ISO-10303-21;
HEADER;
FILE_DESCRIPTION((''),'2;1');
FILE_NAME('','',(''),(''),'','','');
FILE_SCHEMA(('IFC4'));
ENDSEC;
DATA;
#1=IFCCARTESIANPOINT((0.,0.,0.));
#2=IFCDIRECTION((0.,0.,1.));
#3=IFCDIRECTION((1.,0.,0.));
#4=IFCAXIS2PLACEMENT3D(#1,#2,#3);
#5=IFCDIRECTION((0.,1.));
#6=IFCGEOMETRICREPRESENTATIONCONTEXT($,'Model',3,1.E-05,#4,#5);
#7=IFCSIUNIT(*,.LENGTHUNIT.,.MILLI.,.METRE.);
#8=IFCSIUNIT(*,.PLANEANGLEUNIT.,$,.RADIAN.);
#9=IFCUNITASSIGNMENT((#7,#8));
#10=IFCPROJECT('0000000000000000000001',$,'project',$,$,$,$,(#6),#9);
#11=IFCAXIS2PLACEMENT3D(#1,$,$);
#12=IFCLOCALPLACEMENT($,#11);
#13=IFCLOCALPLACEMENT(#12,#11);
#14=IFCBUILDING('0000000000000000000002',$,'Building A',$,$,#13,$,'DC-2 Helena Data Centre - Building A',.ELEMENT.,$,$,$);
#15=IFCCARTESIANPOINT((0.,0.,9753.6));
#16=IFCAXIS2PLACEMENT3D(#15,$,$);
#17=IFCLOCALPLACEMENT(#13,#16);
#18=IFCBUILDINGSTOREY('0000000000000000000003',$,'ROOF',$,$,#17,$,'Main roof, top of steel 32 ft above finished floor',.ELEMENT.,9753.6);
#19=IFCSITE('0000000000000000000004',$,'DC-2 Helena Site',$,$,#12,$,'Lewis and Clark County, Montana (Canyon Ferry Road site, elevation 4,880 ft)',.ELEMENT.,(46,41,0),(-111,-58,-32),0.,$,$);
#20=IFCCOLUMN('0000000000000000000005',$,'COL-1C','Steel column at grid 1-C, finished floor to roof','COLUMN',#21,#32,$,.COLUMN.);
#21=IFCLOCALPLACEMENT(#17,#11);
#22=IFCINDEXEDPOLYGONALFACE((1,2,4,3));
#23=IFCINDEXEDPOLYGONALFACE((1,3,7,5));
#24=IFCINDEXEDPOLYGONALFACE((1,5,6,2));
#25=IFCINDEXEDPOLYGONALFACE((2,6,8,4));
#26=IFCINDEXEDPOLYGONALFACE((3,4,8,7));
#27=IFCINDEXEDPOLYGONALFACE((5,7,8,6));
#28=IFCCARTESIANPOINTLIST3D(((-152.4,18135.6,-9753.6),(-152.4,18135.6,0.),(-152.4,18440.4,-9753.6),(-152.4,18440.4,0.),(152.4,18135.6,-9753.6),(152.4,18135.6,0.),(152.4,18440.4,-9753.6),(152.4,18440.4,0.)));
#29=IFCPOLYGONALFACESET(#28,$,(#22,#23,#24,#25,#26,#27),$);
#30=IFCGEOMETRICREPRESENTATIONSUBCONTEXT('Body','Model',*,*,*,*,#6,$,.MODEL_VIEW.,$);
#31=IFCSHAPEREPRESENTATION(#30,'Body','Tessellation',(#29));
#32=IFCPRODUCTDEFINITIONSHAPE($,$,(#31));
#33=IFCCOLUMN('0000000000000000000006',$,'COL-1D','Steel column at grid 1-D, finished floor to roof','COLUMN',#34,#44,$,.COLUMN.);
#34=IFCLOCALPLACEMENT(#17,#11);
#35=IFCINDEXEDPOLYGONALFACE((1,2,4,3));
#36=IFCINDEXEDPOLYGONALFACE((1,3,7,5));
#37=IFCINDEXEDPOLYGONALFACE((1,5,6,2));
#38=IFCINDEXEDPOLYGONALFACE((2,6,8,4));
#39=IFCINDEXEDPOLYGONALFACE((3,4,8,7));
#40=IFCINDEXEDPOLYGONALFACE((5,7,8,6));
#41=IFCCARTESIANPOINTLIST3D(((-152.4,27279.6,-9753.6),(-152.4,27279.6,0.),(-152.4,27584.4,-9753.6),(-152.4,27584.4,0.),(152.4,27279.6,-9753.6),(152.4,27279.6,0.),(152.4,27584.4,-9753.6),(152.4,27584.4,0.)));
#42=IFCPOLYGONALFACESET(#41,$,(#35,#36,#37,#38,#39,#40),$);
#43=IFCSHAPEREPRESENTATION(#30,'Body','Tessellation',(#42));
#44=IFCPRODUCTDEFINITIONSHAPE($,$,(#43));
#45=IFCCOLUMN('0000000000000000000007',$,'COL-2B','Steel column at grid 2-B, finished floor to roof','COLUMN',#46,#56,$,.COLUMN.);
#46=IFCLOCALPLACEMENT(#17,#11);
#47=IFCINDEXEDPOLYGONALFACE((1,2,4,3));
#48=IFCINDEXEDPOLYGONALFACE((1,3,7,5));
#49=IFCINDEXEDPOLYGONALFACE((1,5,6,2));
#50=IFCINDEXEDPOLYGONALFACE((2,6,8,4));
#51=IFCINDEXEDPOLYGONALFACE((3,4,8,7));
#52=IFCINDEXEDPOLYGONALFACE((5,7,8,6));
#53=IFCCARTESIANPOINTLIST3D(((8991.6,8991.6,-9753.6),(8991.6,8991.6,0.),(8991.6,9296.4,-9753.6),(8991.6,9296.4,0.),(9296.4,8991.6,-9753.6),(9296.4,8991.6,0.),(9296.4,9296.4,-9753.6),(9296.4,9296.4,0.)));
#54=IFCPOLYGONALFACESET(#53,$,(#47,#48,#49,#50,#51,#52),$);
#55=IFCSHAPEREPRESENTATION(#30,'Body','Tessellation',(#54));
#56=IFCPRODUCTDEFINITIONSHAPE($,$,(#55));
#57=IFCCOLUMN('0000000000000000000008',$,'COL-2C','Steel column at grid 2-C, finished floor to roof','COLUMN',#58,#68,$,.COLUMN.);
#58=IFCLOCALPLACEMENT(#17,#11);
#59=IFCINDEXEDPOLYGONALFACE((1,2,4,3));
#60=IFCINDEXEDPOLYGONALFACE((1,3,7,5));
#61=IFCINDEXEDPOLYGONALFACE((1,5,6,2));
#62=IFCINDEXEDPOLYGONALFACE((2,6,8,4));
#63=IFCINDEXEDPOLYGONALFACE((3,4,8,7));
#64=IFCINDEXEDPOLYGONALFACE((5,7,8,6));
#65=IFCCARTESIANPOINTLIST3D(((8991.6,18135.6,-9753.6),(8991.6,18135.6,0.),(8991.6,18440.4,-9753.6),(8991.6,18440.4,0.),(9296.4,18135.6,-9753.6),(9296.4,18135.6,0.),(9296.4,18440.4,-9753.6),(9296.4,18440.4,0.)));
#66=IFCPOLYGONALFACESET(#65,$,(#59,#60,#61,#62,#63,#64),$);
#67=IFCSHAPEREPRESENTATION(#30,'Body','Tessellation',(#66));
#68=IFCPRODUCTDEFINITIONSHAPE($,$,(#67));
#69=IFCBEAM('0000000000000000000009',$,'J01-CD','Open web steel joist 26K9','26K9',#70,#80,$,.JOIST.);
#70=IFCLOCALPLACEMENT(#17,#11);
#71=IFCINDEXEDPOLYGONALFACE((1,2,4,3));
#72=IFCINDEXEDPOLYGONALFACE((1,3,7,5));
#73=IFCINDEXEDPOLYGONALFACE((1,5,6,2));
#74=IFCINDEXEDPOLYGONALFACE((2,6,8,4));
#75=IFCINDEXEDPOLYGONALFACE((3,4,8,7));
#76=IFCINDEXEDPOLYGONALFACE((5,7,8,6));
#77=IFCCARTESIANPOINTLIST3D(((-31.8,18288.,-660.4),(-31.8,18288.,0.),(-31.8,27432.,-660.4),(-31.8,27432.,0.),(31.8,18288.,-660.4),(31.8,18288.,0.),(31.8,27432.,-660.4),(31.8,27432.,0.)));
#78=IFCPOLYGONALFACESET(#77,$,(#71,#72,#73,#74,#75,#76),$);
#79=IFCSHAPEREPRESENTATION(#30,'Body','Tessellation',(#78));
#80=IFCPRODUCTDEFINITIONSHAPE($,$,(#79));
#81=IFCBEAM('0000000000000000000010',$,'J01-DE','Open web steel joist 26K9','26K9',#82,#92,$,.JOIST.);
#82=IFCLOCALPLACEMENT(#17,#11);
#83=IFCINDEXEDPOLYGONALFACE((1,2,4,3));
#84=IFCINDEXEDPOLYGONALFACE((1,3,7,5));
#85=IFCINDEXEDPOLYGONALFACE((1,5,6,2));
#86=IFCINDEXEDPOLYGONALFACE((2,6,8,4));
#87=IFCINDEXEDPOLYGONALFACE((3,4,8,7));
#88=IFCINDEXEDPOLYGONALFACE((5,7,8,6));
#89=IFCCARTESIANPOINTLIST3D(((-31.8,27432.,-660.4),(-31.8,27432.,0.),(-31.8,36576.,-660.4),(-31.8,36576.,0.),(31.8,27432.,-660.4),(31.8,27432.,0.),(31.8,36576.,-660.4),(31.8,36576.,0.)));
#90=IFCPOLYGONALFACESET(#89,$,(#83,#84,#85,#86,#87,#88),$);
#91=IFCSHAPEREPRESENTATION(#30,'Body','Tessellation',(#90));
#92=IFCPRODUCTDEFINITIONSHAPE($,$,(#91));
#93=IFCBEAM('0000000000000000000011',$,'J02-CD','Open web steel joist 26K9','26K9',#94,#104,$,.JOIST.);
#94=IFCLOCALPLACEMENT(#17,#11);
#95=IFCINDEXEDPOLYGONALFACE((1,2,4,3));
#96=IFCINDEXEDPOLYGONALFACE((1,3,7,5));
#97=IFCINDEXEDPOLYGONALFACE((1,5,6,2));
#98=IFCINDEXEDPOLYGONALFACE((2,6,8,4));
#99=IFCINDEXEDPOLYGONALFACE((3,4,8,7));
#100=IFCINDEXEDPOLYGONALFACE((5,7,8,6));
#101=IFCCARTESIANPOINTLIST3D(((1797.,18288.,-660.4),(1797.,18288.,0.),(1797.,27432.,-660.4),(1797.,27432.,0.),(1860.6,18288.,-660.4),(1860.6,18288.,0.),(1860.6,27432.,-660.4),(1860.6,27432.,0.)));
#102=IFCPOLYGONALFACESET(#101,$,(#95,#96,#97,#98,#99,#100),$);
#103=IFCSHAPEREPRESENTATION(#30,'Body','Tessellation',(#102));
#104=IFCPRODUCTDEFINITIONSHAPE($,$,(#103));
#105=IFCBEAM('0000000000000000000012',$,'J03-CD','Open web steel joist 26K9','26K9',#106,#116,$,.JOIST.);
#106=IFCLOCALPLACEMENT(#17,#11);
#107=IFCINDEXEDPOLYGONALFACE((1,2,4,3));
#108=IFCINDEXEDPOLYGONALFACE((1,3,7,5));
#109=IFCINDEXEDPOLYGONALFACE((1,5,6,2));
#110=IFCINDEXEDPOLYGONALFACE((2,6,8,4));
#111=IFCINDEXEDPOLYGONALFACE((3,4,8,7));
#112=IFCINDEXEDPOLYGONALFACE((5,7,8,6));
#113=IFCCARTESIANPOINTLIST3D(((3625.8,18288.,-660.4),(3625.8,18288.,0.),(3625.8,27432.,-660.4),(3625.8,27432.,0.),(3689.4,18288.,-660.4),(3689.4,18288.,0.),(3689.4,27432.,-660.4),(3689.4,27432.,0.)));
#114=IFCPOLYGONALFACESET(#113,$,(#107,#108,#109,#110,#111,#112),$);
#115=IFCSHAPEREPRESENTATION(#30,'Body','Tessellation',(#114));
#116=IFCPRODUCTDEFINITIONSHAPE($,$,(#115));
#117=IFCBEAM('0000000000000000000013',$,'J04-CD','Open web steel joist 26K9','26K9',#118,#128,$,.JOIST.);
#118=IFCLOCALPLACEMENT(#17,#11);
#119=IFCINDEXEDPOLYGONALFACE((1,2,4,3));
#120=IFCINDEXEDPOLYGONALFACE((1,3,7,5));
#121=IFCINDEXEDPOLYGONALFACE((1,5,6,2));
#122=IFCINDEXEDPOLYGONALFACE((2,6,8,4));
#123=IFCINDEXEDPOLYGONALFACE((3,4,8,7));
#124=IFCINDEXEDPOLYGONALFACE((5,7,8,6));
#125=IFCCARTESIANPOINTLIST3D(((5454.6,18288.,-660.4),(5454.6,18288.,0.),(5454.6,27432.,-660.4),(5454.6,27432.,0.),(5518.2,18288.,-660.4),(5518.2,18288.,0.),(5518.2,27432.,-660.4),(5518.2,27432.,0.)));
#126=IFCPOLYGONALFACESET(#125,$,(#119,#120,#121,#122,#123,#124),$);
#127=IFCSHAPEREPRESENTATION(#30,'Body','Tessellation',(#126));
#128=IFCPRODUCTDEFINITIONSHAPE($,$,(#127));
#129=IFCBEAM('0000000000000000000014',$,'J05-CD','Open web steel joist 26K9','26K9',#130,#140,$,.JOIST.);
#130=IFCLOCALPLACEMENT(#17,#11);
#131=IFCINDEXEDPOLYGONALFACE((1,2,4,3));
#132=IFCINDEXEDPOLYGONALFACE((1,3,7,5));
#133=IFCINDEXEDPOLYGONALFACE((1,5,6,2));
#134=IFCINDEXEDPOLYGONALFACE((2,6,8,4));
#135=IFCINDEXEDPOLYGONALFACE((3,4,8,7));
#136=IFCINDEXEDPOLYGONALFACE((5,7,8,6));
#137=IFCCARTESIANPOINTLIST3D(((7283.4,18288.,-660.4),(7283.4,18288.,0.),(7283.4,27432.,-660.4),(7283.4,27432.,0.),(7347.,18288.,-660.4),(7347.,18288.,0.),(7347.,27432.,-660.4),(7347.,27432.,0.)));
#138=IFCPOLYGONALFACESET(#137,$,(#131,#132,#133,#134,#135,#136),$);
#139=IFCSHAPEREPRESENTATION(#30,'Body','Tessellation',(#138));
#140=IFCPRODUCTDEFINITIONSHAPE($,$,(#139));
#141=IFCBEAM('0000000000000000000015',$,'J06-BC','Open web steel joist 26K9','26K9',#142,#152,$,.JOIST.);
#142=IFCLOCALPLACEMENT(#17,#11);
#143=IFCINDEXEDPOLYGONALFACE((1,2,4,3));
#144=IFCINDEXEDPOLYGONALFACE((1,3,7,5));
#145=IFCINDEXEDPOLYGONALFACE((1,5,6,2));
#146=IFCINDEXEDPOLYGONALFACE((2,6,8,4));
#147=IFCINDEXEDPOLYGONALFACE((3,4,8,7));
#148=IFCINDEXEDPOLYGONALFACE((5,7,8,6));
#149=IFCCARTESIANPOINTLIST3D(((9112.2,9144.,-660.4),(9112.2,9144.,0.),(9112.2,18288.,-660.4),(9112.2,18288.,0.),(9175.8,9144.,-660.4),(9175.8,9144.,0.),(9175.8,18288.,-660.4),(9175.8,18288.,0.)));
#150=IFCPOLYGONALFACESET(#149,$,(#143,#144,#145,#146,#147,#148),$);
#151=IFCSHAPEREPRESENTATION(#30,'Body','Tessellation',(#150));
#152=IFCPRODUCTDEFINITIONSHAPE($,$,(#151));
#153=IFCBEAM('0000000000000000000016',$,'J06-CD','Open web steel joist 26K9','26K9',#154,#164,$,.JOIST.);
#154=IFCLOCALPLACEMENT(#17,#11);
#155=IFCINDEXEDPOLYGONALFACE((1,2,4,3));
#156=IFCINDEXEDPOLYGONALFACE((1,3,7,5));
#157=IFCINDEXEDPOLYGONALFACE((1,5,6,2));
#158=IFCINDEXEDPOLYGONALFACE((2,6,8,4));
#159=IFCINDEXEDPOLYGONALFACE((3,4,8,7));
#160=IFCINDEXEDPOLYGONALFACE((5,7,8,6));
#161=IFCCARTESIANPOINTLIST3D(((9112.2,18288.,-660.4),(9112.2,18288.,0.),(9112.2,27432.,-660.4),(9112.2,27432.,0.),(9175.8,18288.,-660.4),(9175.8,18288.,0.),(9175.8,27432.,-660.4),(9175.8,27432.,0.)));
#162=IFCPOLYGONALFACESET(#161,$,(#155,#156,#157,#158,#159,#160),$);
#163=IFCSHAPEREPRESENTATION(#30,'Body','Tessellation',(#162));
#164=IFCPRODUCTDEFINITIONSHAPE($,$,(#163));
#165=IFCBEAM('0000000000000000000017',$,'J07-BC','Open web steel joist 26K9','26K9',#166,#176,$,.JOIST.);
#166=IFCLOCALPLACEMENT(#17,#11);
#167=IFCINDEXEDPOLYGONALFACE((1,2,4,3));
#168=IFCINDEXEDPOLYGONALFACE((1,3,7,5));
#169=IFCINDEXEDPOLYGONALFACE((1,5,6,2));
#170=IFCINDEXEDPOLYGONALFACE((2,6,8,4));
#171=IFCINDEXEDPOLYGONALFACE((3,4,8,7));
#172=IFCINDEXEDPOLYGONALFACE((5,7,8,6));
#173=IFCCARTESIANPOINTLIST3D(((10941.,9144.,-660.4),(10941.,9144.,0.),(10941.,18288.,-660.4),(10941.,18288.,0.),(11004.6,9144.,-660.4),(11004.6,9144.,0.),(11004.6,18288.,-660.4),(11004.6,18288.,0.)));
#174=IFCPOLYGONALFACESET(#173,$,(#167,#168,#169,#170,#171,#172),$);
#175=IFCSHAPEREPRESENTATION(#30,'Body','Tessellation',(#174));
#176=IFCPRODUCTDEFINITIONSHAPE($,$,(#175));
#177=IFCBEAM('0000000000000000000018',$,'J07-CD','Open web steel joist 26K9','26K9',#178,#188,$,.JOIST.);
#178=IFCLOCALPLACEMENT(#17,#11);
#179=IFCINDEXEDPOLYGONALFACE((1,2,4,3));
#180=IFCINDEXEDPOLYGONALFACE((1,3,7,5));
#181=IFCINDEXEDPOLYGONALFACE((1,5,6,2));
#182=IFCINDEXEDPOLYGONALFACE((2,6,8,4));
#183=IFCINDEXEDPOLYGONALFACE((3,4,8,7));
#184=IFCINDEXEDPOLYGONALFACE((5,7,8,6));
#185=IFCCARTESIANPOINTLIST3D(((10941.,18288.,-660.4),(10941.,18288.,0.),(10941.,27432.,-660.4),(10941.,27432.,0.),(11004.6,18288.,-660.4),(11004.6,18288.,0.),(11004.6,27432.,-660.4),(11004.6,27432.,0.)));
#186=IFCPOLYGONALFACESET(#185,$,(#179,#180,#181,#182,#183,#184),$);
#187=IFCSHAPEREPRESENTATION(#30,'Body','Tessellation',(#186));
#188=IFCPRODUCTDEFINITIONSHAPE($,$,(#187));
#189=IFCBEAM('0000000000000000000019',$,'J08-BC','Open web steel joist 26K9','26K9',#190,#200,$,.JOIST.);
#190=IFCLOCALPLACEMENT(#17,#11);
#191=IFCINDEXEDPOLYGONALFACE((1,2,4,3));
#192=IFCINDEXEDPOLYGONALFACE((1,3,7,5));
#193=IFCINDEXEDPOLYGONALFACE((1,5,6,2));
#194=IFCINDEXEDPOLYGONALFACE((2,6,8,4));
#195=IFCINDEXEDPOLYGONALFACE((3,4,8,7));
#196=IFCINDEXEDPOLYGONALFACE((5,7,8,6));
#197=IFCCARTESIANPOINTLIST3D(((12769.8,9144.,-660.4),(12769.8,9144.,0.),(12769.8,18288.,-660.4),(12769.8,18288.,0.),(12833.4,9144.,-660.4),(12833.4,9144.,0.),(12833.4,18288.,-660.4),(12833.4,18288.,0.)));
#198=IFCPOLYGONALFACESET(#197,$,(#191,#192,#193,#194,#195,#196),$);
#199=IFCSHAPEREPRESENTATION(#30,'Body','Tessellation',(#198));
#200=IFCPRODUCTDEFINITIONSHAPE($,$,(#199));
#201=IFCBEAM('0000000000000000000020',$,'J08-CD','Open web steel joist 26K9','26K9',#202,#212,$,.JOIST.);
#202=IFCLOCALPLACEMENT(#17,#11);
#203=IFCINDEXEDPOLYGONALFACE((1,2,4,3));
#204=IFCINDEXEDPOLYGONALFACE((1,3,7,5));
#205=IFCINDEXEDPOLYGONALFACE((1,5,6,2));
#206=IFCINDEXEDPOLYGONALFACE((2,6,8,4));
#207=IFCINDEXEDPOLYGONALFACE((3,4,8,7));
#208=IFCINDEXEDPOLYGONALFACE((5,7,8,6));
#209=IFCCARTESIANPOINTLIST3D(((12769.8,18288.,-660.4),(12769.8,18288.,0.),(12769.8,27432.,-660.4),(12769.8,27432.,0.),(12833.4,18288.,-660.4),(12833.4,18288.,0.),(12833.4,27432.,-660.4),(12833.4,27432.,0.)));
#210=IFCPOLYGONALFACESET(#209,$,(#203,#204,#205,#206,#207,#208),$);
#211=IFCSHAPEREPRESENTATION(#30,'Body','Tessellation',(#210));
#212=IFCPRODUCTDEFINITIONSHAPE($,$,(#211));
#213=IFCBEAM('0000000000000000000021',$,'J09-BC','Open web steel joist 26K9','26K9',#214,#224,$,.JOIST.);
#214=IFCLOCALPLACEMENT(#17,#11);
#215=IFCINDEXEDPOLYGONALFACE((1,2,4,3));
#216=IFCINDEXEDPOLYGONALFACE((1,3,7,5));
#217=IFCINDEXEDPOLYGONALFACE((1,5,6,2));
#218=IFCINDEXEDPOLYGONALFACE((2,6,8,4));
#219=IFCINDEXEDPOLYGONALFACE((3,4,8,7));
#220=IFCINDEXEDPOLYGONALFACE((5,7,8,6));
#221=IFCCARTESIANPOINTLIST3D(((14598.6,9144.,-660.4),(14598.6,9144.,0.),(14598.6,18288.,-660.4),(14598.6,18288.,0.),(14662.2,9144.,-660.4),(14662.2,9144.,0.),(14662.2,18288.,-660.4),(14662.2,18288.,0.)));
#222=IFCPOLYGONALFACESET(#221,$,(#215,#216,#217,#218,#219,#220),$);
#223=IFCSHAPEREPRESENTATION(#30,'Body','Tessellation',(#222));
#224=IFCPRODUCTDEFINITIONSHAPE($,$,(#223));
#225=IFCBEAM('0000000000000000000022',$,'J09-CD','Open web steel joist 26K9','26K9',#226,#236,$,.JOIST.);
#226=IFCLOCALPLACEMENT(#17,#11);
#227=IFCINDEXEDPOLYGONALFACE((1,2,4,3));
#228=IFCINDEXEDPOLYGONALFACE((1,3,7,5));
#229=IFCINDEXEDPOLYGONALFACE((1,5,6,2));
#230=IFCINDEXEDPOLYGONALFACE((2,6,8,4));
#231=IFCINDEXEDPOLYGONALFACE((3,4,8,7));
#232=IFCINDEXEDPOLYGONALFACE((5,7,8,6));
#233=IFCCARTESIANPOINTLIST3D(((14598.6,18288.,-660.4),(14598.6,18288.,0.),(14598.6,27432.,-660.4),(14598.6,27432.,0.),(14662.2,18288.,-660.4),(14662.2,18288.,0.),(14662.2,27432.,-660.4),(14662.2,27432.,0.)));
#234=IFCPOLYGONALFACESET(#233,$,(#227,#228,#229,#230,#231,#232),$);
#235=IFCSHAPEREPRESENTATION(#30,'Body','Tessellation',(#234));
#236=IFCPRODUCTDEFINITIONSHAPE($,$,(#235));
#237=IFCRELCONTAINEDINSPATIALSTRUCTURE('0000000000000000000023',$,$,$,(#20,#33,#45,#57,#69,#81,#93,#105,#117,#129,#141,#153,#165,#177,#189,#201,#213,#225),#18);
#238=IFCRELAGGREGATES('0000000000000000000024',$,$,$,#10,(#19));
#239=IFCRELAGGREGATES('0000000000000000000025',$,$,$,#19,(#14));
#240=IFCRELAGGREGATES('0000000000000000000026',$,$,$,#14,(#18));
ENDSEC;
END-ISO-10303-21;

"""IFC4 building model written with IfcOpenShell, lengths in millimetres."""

from ifc_helpers import new_model, si_unit, direction, frame, origin, origin_with_axes, origin_2d, place, context, subcontext, project, spatial, rectangle, extrude, element, save


model = new_model("IFC4")

# Units and contexts
model_context = context("Model", 3, precision=1e-05, world=origin_with_axes(), true_north=direction((0.0, 1.0)))
body_context = subcontext(model_context, "Body", "Model", "MODEL_VIEW")
ifc_project = project(units=[si_unit("LENGTHUNIT", "METRE", prefix="MILLI"), si_unit("PLANEANGLEUNIT", "RADIAN")], contexts=[model_context])

# Site, building, storey
site_placement = place(None, origin())
site = spatial("IfcSite", under=ifc_project, at=site_placement, Name="DC-2 Helena Site", LongName="Lewis and Clark County, Montana (Canyon Ferry Road site, elevation 4,880 ft)", CompositionType="ELEMENT", RefLatitude=(46, 41, 0), RefLongitude=(-111, -58, -32), RefElevation=0.0)
building_placement = place(site_placement, origin())
building = spatial("IfcBuilding", under=site, at=building_placement, Name="Building A", LongName="DC-2 Helena Data Centre - Building A", CompositionType="ELEMENT")
storey_placement = place(building_placement, frame((0.0, 0.0, 9753.6)))
storey = spatial("IfcBuildingStorey", under=building, at=storey_placement, Name="ROOF", LongName="Main roof, top of steel 32 ft above finished floor", CompositionType="ELEMENT", Elevation=9753.6)

# Columns
placement_1 = place(storey_placement, frame((0.0, 18288.0, -9753.6)))
element("IfcColumn", 1, at=placement_1, inside=storey, Name="COL-1C", Description="Steel column at grid 1-C, finished floor to roof", ObjectType="COLUMN", PredefinedType="COLUMN", context=body_context, shape_type="SweptSolid", body=[
    extrude(rectangle(XDim=304.8, YDim=304.8, at=origin_2d()), origin(), (0.0, 0.0, 1.0), 9753.6),
])
for number, where, name, description in (
    (2, (0.0, 27432.0, -9753.6), "COL-1D", "Steel column at grid 1-D, finished floor to roof"),
    (3, (9144.0, 9144.0, -9753.6), "COL-2B", "Steel column at grid 2-B, finished floor to roof"),
    (4, (9144.0, 18288.0, -9753.6), "COL-2C", "Steel column at grid 2-C, finished floor to roof"),
):
    element("IfcColumn", number, at=place(storey_placement, frame(where)), inside=storey, Name=name, Description=description, ObjectType="COLUMN", PredefinedType="COLUMN", context=body_context, shape_type="SweptSolid", body=[
        extrude(rectangle(XDim=304.8, YDim=304.8, at=origin_2d()), origin(), (0.0, 0.0, 1.0), 9753.6),
    ])

# Beams
placement_2 = place(storey_placement, frame((0.0, 18288.0, 0.0)))
element("IfcBeam", 5, at=placement_2, inside=storey, Name="J01-CD", Description="Open web steel joist 26K9", ObjectType="26K9", PredefinedType="JOIST", context=body_context, shape_type="SweptSolid", body=[
    extrude(rectangle(XDim=63.5, YDim=660.4, at=origin_2d()), frame((0.0, 0.0, -330.2), z_axis=(0.0, 1.0, 0.0), x_axis=(1.0, 0.0, 0.0)), (0.0, 0.0, 1.0), 9144.0),
])
placement_3 = place(storey_placement, frame((0.0, 27432.0, 0.0)))
element("IfcBeam", 6, at=placement_3, inside=storey, Name="J01-DE", Description="Open web steel joist 26K9", ObjectType="26K9", PredefinedType="JOIST", context=body_context, shape_type="SweptSolid", body=[
    extrude(rectangle(XDim=63.5, YDim=660.4, at=origin_2d()), frame((0.0, 0.0, -330.2), z_axis=(0.0, 1.0, 0.0), x_axis=(1.0, 0.0, 0.0)), (0.0, 0.0, 1.0), 9144.0),
])
for number, where, name in (
    (7, (1828.8, 18288.0, 0.0), "J02-CD"),
    (8, (3657.6, 18288.0, 0.0), "J03-CD"),
    (9, (5486.4, 18288.0, 0.0), "J04-CD"),
    (10, (7315.2, 18288.0, 0.0), "J05-CD"),
):
    element("IfcBeam", number, at=place(storey_placement, frame(where)), inside=storey, Name=name, Description="Open web steel joist 26K9", ObjectType="26K9", PredefinedType="JOIST", context=body_context, shape_type="SweptSolid", body=[
        extrude(rectangle(XDim=63.5, YDim=660.4, at=origin_2d()), frame((0.0, 0.0, -330.2), z_axis=(0.0, 1.0, 0.0), x_axis=(1.0, 0.0, 0.0)), (0.0, 0.0, 1.0), 9144.0),
    ])
placement_4 = place(storey_placement, frame((9144.0, 9144.0, 0.0)))
element("IfcBeam", 11, at=placement_4, inside=storey, Name="J06-BC", Description="Open web steel joist 26K9", ObjectType="26K9", PredefinedType="JOIST", context=body_context, shape_type="SweptSolid", body=[
    extrude(rectangle(XDim=63.5, YDim=660.4, at=origin_2d()), frame((0.0, 0.0, -330.2), z_axis=(0.0, 1.0, 0.0), x_axis=(1.0, 0.0, 0.0)), (0.0, 0.0, 1.0), 9144.0),
])
placement_5 = place(storey_placement, frame((9144.0, 18288.0, 0.0)))
element("IfcBeam", 12, at=placement_5, inside=storey, Name="J06-CD", Description="Open web steel joist 26K9", ObjectType="26K9", PredefinedType="JOIST", context=body_context, shape_type="SweptSolid", body=[
    extrude(rectangle(XDim=63.5, YDim=660.4, at=origin_2d()), frame((0.0, 0.0, -330.2), z_axis=(0.0, 1.0, 0.0), x_axis=(1.0, 0.0, 0.0)), (0.0, 0.0, 1.0), 9144.0),
])
for number, where, name in (
    (13, (10972.8, 9144.0, 0.0), "J07-BC"),
    (14, (10972.8, 18288.0, 0.0), "J07-CD"),
    (15, (12801.6, 9144.0, 0.0), "J08-BC"),
    (16, (12801.6, 18288.0, 0.0), "J08-CD"),
    (17, (14630.4, 9144.0, 0.0), "J09-BC"),
    (18, (14630.4, 18288.0, 0.0), "J09-CD"),
):
    element("IfcBeam", number, at=place(storey_placement, frame(where)), inside=storey, Name=name, Description="Open web steel joist 26K9", ObjectType="26K9", PredefinedType="JOIST", context=body_context, shape_type="SweptSolid", body=[
        extrude(rectangle(XDim=63.5, YDim=660.4, at=origin_2d()), frame((0.0, 0.0, -330.2), z_axis=(0.0, 1.0, 0.0), x_axis=(1.0, 0.0, 0.0)), (0.0, 0.0, 1.0), 9144.0),
    ])

save(model, "model.ifc")
